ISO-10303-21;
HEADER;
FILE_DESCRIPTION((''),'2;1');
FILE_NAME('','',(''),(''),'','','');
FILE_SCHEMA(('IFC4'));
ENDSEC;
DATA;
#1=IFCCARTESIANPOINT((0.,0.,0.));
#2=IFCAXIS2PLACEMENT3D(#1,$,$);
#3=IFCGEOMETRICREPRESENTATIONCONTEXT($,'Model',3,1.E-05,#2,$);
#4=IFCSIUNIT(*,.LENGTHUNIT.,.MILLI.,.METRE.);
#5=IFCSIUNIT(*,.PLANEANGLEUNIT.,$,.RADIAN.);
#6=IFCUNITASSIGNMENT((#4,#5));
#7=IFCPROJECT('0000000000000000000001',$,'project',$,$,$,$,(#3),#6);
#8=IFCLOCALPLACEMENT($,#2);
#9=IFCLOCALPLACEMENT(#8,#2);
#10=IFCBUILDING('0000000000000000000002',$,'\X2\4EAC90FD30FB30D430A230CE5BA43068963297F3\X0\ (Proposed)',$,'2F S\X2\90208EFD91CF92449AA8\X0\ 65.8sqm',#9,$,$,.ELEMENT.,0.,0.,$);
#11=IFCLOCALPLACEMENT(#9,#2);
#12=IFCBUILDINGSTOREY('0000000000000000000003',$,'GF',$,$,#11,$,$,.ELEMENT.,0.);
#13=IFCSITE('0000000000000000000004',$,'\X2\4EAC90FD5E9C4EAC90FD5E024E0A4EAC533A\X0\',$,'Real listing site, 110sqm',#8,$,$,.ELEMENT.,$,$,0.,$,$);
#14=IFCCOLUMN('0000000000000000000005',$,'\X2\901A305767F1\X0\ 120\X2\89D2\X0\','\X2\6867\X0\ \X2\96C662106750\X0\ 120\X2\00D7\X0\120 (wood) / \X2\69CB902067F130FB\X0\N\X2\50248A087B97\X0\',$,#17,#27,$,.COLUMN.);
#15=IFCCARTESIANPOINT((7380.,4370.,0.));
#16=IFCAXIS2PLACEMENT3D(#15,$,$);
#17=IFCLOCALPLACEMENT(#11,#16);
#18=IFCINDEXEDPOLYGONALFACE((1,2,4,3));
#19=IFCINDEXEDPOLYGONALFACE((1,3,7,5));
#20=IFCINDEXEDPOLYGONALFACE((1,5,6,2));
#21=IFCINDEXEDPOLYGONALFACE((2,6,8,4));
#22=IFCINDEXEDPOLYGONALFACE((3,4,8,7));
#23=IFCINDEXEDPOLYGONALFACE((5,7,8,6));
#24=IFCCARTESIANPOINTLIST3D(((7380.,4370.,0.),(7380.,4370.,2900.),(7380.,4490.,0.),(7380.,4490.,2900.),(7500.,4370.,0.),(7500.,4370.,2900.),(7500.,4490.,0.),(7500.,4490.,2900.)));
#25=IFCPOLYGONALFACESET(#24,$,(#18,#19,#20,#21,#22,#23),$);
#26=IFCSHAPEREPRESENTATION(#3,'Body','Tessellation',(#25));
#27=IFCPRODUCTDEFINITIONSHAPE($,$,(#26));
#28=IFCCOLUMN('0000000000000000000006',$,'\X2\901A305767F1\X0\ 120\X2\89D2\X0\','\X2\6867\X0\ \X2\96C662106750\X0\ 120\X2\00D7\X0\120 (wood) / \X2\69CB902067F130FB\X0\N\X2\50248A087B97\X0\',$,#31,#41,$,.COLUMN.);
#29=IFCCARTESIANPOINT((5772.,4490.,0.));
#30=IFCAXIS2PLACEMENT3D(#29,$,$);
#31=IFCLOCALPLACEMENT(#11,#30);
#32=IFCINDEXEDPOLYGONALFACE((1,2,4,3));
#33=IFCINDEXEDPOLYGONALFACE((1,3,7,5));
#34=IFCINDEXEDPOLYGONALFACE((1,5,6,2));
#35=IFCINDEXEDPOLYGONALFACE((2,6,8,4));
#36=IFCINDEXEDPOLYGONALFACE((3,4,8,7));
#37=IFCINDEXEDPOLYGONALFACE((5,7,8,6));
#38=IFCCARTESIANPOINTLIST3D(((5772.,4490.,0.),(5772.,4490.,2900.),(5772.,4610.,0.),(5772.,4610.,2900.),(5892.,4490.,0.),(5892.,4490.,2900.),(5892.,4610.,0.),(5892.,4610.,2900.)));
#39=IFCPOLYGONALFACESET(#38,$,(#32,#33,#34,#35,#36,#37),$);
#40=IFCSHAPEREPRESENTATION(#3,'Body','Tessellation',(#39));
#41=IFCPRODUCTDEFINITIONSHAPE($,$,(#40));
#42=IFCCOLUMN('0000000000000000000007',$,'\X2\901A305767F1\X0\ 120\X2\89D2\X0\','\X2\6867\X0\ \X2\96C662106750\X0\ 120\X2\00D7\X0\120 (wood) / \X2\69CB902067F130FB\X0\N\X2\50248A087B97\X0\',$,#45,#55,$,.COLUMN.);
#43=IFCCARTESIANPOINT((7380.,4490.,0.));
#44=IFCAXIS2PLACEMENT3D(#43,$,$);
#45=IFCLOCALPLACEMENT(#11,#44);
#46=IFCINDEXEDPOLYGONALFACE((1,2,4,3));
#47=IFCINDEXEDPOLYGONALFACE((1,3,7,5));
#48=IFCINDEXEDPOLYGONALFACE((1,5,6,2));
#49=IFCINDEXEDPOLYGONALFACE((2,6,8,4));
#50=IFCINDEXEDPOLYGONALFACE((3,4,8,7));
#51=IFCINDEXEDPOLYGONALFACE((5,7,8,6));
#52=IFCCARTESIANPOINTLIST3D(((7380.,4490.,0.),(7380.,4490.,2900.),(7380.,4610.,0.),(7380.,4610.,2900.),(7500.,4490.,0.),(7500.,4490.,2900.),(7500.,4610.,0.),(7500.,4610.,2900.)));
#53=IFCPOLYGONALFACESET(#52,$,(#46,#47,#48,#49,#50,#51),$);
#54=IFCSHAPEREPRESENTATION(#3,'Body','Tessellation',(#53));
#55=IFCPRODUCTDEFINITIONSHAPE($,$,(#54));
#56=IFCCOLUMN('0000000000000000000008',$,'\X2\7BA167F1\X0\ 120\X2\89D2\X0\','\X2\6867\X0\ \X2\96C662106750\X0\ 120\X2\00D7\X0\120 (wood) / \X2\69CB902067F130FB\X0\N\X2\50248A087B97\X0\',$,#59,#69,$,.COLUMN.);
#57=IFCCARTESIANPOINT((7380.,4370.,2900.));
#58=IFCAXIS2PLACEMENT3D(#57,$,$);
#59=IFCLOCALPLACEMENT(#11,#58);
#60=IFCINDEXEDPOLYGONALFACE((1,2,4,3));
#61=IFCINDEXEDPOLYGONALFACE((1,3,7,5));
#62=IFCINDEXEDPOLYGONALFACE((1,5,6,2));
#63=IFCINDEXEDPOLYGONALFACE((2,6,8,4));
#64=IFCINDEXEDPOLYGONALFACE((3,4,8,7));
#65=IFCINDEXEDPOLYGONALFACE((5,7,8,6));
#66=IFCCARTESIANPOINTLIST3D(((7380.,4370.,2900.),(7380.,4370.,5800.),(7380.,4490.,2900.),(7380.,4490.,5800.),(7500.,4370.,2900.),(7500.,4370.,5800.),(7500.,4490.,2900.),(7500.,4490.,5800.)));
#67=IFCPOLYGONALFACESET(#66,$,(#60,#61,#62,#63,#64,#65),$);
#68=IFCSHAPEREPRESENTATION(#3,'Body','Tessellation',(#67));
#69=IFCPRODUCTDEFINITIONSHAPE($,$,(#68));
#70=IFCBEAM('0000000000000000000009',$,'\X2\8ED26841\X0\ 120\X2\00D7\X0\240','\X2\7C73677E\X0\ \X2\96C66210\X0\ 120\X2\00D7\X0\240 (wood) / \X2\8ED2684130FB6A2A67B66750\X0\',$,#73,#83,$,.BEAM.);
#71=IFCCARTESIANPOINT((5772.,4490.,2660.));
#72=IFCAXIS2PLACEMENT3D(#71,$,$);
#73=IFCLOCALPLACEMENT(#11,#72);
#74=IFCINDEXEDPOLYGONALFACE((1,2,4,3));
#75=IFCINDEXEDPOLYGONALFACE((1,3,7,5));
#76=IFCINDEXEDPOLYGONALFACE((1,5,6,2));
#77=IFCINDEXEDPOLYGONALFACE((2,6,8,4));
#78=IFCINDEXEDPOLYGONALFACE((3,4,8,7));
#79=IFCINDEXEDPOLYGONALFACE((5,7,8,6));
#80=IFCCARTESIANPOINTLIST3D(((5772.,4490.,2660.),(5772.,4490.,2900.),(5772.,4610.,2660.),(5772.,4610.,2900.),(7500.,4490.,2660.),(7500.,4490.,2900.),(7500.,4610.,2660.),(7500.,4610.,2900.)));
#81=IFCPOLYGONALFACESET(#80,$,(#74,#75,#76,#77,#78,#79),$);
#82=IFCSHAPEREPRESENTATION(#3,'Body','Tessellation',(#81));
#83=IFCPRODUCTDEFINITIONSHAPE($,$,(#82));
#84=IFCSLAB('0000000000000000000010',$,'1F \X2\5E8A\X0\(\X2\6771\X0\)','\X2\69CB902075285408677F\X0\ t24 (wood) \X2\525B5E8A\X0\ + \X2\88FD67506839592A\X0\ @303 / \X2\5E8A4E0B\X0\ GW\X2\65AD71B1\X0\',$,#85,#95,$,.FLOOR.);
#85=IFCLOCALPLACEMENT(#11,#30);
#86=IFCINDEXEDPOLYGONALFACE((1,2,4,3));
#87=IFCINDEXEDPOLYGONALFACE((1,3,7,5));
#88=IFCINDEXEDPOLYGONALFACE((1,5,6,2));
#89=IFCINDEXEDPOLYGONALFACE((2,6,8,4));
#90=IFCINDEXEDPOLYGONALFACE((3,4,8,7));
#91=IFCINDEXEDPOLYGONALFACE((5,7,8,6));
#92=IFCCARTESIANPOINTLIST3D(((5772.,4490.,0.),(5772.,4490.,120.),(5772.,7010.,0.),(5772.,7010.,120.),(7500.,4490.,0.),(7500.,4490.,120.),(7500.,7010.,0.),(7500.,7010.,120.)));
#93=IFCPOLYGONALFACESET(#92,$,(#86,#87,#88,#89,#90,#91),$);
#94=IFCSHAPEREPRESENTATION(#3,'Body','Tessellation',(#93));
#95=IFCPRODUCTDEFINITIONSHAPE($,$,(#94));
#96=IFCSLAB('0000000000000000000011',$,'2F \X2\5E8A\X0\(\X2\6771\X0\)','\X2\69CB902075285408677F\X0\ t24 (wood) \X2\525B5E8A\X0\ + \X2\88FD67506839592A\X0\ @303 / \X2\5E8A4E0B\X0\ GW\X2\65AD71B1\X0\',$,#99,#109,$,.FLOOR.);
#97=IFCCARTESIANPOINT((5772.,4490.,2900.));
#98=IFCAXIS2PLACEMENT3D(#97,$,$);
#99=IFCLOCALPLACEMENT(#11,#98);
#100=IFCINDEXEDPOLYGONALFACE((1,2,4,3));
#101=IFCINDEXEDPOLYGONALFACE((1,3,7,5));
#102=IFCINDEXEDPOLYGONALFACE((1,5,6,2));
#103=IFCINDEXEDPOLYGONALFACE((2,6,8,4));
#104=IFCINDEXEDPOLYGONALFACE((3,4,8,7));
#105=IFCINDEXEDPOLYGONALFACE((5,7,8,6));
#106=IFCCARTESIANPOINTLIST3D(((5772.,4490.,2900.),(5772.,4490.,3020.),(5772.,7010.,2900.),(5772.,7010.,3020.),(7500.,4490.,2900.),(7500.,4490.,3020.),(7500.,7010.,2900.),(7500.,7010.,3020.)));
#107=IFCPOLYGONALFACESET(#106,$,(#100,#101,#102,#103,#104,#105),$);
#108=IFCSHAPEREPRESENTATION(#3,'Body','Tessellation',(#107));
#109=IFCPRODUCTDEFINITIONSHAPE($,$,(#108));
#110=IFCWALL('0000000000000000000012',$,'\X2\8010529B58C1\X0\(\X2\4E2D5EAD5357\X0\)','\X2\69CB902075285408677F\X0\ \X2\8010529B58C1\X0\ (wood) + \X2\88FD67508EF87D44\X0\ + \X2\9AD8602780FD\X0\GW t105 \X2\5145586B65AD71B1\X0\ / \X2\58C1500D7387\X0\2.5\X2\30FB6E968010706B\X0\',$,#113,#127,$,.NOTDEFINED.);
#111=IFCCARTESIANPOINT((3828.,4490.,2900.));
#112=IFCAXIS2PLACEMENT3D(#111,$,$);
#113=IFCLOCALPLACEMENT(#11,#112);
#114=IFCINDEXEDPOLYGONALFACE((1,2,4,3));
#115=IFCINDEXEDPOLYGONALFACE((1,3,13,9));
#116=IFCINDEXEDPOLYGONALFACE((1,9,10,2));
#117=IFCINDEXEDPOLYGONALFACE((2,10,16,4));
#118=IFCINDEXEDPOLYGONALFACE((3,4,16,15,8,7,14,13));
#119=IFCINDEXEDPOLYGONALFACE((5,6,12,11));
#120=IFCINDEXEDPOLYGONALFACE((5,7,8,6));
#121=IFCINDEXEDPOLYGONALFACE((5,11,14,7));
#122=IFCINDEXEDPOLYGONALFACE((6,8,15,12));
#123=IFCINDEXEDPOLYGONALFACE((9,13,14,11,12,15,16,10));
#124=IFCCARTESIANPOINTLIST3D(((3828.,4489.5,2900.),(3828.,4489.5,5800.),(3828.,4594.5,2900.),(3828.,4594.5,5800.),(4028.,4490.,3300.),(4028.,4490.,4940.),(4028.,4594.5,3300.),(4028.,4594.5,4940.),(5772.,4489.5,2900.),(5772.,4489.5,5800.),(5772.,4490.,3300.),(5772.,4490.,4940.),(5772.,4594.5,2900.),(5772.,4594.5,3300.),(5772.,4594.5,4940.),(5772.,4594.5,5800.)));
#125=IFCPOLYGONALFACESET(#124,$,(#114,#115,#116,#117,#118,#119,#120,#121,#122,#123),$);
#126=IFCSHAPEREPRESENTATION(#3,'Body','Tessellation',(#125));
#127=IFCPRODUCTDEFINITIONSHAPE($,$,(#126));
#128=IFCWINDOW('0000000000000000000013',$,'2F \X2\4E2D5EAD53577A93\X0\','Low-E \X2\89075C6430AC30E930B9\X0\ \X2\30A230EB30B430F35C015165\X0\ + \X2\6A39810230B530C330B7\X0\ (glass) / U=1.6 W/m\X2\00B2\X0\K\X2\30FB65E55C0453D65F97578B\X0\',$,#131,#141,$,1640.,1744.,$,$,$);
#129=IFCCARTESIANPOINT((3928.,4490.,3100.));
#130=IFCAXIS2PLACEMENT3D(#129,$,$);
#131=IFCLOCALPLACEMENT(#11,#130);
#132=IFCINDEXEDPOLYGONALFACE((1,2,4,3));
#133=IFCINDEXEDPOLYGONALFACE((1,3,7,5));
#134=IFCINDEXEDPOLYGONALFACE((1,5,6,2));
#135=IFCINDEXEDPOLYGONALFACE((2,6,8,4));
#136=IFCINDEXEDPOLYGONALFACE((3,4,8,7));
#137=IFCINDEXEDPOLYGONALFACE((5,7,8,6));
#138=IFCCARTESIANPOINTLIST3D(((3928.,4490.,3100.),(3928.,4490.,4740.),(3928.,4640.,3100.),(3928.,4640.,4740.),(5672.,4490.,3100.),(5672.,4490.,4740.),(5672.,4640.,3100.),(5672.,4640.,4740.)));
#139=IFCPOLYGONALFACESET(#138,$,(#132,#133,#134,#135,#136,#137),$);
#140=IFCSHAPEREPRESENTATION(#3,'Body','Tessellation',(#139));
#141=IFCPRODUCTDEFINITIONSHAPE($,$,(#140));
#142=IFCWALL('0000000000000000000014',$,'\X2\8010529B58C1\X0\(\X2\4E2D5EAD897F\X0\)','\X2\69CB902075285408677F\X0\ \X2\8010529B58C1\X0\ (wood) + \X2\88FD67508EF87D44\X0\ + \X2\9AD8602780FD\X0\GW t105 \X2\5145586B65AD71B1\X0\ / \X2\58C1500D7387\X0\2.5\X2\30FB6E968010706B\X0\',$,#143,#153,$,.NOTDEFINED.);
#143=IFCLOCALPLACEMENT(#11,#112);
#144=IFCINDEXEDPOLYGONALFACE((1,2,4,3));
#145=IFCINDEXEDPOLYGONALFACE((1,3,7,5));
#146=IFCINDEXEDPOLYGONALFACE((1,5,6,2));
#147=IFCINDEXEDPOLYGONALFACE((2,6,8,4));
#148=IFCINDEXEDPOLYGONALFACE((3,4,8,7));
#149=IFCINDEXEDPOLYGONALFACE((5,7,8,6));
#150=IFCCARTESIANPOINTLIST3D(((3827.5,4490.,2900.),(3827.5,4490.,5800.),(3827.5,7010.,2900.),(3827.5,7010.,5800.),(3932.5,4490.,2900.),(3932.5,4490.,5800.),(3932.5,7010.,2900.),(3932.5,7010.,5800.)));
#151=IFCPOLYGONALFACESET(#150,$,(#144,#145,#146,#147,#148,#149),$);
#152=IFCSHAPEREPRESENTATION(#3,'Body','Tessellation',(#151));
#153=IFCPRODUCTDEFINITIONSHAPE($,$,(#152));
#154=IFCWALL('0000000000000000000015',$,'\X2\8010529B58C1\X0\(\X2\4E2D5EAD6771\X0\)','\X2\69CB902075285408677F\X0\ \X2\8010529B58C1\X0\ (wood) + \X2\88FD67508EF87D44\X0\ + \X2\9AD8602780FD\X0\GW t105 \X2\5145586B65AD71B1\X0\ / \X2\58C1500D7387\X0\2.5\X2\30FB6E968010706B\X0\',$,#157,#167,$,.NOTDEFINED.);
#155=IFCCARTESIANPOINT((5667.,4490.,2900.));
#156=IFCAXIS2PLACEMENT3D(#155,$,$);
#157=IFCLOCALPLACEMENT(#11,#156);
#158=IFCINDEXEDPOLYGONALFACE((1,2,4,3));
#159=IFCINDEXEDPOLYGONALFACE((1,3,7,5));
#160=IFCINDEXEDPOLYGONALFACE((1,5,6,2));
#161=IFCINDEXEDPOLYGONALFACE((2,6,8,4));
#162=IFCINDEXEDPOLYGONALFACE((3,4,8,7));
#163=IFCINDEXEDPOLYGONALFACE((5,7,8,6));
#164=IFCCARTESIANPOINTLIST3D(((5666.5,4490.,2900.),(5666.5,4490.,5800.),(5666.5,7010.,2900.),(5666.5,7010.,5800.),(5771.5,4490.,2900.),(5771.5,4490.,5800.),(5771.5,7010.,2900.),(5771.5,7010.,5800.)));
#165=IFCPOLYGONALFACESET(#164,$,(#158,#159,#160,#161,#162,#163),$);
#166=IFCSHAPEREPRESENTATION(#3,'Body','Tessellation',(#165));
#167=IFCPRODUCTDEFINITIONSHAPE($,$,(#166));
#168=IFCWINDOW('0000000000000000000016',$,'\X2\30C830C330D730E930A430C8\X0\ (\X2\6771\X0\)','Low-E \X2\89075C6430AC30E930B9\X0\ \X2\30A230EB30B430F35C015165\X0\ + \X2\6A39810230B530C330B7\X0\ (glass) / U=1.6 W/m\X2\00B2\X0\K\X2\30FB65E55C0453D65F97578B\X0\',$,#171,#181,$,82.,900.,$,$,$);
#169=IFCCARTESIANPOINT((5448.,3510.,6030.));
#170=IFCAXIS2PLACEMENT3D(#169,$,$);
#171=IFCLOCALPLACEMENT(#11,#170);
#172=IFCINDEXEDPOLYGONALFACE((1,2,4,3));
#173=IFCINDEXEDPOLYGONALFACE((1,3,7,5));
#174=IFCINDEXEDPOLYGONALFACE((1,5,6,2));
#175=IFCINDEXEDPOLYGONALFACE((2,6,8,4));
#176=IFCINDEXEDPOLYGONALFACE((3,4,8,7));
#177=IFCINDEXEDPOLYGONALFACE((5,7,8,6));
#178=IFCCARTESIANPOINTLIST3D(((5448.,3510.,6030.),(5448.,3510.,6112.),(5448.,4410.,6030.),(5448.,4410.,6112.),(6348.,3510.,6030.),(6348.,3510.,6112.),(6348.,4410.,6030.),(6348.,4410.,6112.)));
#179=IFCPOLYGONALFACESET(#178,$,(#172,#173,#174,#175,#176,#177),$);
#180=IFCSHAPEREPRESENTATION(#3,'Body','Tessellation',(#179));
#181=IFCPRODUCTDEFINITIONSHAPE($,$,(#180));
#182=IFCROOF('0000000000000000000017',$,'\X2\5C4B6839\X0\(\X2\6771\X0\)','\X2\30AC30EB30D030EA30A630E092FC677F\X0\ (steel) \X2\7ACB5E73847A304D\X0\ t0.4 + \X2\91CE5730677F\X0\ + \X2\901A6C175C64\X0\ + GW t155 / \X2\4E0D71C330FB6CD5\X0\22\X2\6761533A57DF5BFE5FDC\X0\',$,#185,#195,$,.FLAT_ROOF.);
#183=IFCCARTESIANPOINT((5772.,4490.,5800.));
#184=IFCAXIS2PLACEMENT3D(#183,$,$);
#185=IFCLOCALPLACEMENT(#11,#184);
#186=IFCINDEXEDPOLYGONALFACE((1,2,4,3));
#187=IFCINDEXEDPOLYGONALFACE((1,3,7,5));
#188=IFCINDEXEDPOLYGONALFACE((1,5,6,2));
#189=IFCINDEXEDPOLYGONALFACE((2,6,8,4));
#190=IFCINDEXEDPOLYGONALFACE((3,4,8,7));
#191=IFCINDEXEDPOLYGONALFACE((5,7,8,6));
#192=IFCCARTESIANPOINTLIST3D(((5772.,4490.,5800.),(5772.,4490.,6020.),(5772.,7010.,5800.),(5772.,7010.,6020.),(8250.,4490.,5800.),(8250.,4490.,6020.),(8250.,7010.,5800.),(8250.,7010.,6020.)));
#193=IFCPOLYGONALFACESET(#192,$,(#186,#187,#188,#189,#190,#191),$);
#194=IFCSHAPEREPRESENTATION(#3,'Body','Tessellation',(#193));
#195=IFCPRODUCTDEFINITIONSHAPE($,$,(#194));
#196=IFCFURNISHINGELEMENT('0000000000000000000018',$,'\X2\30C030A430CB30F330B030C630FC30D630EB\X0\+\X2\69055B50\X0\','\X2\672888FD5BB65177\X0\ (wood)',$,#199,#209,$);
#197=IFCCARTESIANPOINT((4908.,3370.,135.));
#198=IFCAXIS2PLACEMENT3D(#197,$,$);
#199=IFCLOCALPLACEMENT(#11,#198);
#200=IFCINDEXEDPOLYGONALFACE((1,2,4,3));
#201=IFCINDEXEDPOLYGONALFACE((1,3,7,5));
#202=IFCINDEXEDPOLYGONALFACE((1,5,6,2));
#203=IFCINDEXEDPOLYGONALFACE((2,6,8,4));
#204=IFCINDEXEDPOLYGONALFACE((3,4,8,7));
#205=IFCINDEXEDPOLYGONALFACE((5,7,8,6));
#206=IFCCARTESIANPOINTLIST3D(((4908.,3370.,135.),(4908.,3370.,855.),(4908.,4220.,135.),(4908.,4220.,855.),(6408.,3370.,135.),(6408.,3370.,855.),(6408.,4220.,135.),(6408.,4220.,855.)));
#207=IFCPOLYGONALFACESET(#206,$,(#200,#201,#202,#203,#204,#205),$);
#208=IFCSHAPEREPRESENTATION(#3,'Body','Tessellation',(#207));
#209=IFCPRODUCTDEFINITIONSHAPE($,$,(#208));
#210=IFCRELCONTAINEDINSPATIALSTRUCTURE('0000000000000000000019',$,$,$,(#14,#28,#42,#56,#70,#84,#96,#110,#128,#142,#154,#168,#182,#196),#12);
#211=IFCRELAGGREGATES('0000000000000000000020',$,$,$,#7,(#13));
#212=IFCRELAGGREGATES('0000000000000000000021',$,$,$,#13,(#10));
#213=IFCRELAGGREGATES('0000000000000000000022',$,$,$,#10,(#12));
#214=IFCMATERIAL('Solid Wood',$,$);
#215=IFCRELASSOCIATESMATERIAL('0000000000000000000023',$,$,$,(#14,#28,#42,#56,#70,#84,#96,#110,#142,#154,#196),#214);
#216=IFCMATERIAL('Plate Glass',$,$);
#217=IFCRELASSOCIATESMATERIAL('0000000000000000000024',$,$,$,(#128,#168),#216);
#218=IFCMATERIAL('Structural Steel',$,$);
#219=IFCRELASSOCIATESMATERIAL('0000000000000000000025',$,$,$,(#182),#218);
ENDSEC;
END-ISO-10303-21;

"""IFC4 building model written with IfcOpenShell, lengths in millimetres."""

from ifc_helpers import new_model, si_unit, frame, frame_2d, origin, place, context, project, spatial, rectangle, extrude, material, element, fill, save


model = new_model("IFC4")

# Units and contexts
model_context = context("Model", 3, precision=1e-05, world=origin())
ifc_project = project(units=[si_unit("LENGTHUNIT", "METRE", prefix="MILLI"), si_unit("PLANEANGLEUNIT", "RADIAN")], contexts=[model_context])

# Site, building, storey
site_placement = place(None, origin())
site = spatial("IfcSite", under=ifc_project, at=site_placement, Name="京都府京都市上京区", ObjectType="Real listing site, 110sqm", CompositionType="ELEMENT", RefElevation=0.0)
building_placement = place(site_placement, origin())
building = spatial("IfcBuilding", under=site, at=building_placement, Name="京都・ピアノ室と防音 (Proposed)", ObjectType="2F S造軽量鉄骨 65.8sqm", CompositionType="ELEMENT", ElevationOfRefHeight=0.0, ElevationOfTerrain=0.0)
storey_placement = place(building_placement, origin())
storey = spatial("IfcBuildingStorey", under=building, at=storey_placement, Name="GF", CompositionType="ELEMENT", Elevation=0.0)

# Columns
ifc_material_1 = material(Name="Solid Wood")
column_1_placement = place(storey_placement, frame((7380.0, 4370.0, 0.0)))
element("IfcColumn", 1, at=column_1_placement, inside=storey, material=ifc_material_1, Name="通し柱 120角", Description="桧 集成材 120×120 (wood) / 構造柱・N値計算", PredefinedType="COLUMN", context=model_context, shape_type="SweptSolid", body=[
    extrude(rectangle(XDim=120.0, YDim=120.0, at=frame_2d((60.0, 60.0))), frame((7380.0, 4370.0, 0.0)), (0.0, 0.0, 1.0), 2900.0),
])
column_2_placement = place(storey_placement, frame((5772.0, 4490.0, 0.0)))
element("IfcColumn", 2, at=column_2_placement, inside=storey, material=ifc_material_1, Name="通し柱 120角", Description="桧 集成材 120×120 (wood) / 構造柱・N値計算", PredefinedType="COLUMN", context=model_context, shape_type="SweptSolid", body=[
    extrude(rectangle(XDim=120.0, YDim=120.0, at=frame_2d((60.0, 60.0))), frame((5772.0, 4490.0, 0.0)), (0.0, 0.0, 1.0), 2900.0),
])
column_3_placement = place(storey_placement, frame((7380.0, 4490.0, 0.0)))
element("IfcColumn", 3, at=column_3_placement, inside=storey, material=ifc_material_1, Name="通し柱 120角", Description="桧 集成材 120×120 (wood) / 構造柱・N値計算", PredefinedType="COLUMN", context=model_context, shape_type="SweptSolid", body=[
    extrude(rectangle(XDim=120.0, YDim=120.0, at=frame_2d((60.0, 60.0))), frame((7380.0, 4490.0, 0.0)), (0.0, 0.0, 1.0), 2900.0),
])
column_4_placement = place(storey_placement, frame((7380.0, 4370.0, 2900.0)))
element("IfcColumn", 4, at=column_4_placement, inside=storey, material=ifc_material_1, Name="管柱 120角", Description="桧 集成材 120×120 (wood) / 構造柱・N値計算", PredefinedType="COLUMN", context=model_context, shape_type="SweptSolid", body=[
    extrude(rectangle(XDim=120.0, YDim=120.0, at=frame_2d((60.0, 60.0))), frame((7380.0, 4370.0, 2900.0)), (0.0, 0.0, 1.0), 2900.0),
])

# Beam
beam_1_placement = place(storey_placement, frame((5772.0, 4490.0, 2660.0)))
element("IfcBeam", 5, at=beam_1_placement, inside=storey, material=ifc_material_1, Name="軒桁 120×240", Description="米松 集成 120×240 (wood) / 軒桁・横架材", PredefinedType="BEAM", context=model_context, shape_type="SweptSolid", body=[
    extrude(rectangle(XDim=1728.0, YDim=120.0, at=frame_2d((864.0, 60.0))), frame((5772.0, 4490.0, 2660.0)), (0.0, 0.0, 1.0), 240.0),
])

# Slabs
slab_1_placement = place(storey_placement, frame((5772.0, 4490.0, 0.0)))
element("IfcSlab", 6, at=slab_1_placement, inside=storey, material=ifc_material_1, Name="1F 床(東)", Description="構造用合板 t24 (wood) 剛床 + 製材根太 @303 / 床下 GW断熱", PredefinedType="FLOOR", context=model_context, shape_type="SweptSolid", body=[
    extrude(rectangle(XDim=1728.0, YDim=2520.0, at=frame_2d((864.0, 1260.0))), frame((5772.0, 4490.0, 0.0)), (0.0, 0.0, 1.0), 120.0),
])
slab_2_placement = place(storey_placement, frame((5772.0, 4490.0, 2900.0)))
element("IfcSlab", 7, at=slab_2_placement, inside=storey, material=ifc_material_1, Name="2F 床(東)", Description="構造用合板 t24 (wood) 剛床 + 製材根太 @303 / 床下 GW断熱", PredefinedType="FLOOR", context=model_context, shape_type="SweptSolid", body=[
    extrude(rectangle(XDim=1728.0, YDim=2520.0, at=frame_2d((864.0, 1260.0))), frame((5772.0, 4490.0, 2900.0)), (0.0, 0.0, 1.0), 120.0),
])

# Wall, opening, window
wall_1_placement = place(storey_placement, frame((3828.0, 4490.0, 2900.0)))
wall_1 = element("IfcWall", 8, at=wall_1_placement, inside=storey, material=ifc_material_1, Name="耐力壁(中庭南)", Description="構造用合板 耐力壁 (wood) + 製材軸組 + 高性能GW t105 充填断熱 / 壁倍率2.5・準耐火", PredefinedType="NOTDEFINED", context=model_context, shape_type="SweptSolid", body=[
    extrude(rectangle(XDim=1944.0, YDim=105.0, at=frame_2d((972.0, 52.0))), frame((3828.0, 4490.0, 2900.0)), (0.0, 0.0, 1.0), 2900.0),
])
opening_placement = place(storey_placement, frame((3928.0, 4490.0, 3100.0)))
opening = element("IfcOpeningElement", 9, at=opening_placement, cuts=wall_1, PredefinedType="NOTDEFINED", context=model_context, shape_type="SweptSolid", body=[
    extrude(rectangle(XDim=1744.0, YDim=150.0, at=frame_2d((872.0, 75.0))), frame((3928.0, 4490.0, 3100.0)), (0.0, 0.0, 1.0), 1640.0),
])
ifc_material_2 = material(Name="Plate Glass")
window_1_placement = place(storey_placement, frame((3928.0, 4490.0, 3100.0)))
window_1 = element("IfcWindow", 10, at=window_1_placement, inside=storey, material=ifc_material_2, Name="2F 中庭南窓", Description="Low-E 複層ガラス アルゴン封入 + 樹脂サッシ (glass) / U=1.6 W/m²K・日射取得型", OverallHeight=1640.0, OverallWidth=1744.0, context=model_context, shape_type="SweptSolid", body=[
    extrude(rectangle(XDim=1744.0, YDim=150.0, at=frame_2d((872.0, 75.0))), frame((3928.0, 4490.0, 3100.0)), (0.0, 0.0, 1.0), 1640.0),
])
fill(opening, window_1)

# Walls
wall_2_placement = place(storey_placement, frame((3828.0, 4490.0, 2900.0)))
element("IfcWall", 11, at=wall_2_placement, inside=storey, material=ifc_material_1, Name="耐力壁(中庭西)", Description="構造用合板 耐力壁 (wood) + 製材軸組 + 高性能GW t105 充填断熱 / 壁倍率2.5・準耐火", PredefinedType="NOTDEFINED", context=model_context, shape_type="SweptSolid", body=[
    extrude(rectangle(XDim=105.0, YDim=2520.0, at=frame_2d((52.0, 1260.0))), frame((3828.0, 4490.0, 2900.0)), (0.0, 0.0, 1.0), 2900.0),
])
wall_3_placement = place(storey_placement, frame((5667.0, 4490.0, 2900.0)))
element("IfcWall", 12, at=wall_3_placement, inside=storey, material=ifc_material_1, Name="耐力壁(中庭東)", Description="構造用合板 耐力壁 (wood) + 製材軸組 + 高性能GW t105 充填断熱 / 壁倍率2.5・準耐火", PredefinedType="NOTDEFINED", context=model_context, shape_type="SweptSolid", body=[
    extrude(rectangle(XDim=105.0, YDim=2520.0, at=frame_2d((52.0, 1260.0))), frame((5667.0, 4490.0, 2900.0)), (0.0, 0.0, 1.0), 2900.0),
])

# Window
window_2_placement = place(storey_placement, frame((5448.0, 3510.0, 6030.0)))
element("IfcWindow", 13, at=window_2_placement, inside=storey, material=ifc_material_2, Name="トップライト (東)", Description="Low-E 複層ガラス アルゴン封入 + 樹脂サッシ (glass) / U=1.6 W/m²K・日射取得型", OverallHeight=82.0, OverallWidth=900.0, context=model_context, shape_type="SweptSolid", body=[
    extrude(rectangle(XDim=900.0, YDim=900.0, at=frame_2d((450.0, 450.0))), frame((5448.0, 3510.0, 6030.0)), (0.0, 0.0, 1.0), 82.0),
])

# Roof
ifc_material_3 = material(Name="Structural Steel")
for number, where, name in (
    (14, (5772.0, 4490.0, 5800.0), "屋根(東)"),
):
    element("IfcRoof", number, at=place(storey_placement, frame(where)), inside=storey, material=ifc_material_3, Name=name, Description="ガルバリウム鋼板 (steel) 立平葺き t0.4 + 野地板 + 通気層 + GW t155 / 不燃・法22条区域対応", PredefinedType="FLAT_ROOF", context=model_context, shape_type="SweptSolid", body=[
        extrude(rectangle(XDim=2478.0, YDim=2520.0, at=frame_2d((1239.0, 1260.0))), frame((5772.0, 4490.0, 5800.0)), (0.0, 0.0, 1.0), 220.0),
    ])

# Furnishing element
furnishing_1_placement = place(storey_placement, frame((4908.0, 3370.0, 135.0)))
element("IfcFurnishingElement", 15, at=furnishing_1_placement, inside=storey, material=ifc_material_1, Name="ダイニングテーブル+椅子", Description="木製家具 (wood)", context=model_context, shape_type="SweptSolid", body=[
    extrude(rectangle(XDim=1500.0, YDim=850.0, at=frame_2d((750.0, 425.0))), frame((4908.0, 3370.0, 135.0)), (0.0, 0.0, 1.0), 720.0),
])

save(model, "model.ifc")
